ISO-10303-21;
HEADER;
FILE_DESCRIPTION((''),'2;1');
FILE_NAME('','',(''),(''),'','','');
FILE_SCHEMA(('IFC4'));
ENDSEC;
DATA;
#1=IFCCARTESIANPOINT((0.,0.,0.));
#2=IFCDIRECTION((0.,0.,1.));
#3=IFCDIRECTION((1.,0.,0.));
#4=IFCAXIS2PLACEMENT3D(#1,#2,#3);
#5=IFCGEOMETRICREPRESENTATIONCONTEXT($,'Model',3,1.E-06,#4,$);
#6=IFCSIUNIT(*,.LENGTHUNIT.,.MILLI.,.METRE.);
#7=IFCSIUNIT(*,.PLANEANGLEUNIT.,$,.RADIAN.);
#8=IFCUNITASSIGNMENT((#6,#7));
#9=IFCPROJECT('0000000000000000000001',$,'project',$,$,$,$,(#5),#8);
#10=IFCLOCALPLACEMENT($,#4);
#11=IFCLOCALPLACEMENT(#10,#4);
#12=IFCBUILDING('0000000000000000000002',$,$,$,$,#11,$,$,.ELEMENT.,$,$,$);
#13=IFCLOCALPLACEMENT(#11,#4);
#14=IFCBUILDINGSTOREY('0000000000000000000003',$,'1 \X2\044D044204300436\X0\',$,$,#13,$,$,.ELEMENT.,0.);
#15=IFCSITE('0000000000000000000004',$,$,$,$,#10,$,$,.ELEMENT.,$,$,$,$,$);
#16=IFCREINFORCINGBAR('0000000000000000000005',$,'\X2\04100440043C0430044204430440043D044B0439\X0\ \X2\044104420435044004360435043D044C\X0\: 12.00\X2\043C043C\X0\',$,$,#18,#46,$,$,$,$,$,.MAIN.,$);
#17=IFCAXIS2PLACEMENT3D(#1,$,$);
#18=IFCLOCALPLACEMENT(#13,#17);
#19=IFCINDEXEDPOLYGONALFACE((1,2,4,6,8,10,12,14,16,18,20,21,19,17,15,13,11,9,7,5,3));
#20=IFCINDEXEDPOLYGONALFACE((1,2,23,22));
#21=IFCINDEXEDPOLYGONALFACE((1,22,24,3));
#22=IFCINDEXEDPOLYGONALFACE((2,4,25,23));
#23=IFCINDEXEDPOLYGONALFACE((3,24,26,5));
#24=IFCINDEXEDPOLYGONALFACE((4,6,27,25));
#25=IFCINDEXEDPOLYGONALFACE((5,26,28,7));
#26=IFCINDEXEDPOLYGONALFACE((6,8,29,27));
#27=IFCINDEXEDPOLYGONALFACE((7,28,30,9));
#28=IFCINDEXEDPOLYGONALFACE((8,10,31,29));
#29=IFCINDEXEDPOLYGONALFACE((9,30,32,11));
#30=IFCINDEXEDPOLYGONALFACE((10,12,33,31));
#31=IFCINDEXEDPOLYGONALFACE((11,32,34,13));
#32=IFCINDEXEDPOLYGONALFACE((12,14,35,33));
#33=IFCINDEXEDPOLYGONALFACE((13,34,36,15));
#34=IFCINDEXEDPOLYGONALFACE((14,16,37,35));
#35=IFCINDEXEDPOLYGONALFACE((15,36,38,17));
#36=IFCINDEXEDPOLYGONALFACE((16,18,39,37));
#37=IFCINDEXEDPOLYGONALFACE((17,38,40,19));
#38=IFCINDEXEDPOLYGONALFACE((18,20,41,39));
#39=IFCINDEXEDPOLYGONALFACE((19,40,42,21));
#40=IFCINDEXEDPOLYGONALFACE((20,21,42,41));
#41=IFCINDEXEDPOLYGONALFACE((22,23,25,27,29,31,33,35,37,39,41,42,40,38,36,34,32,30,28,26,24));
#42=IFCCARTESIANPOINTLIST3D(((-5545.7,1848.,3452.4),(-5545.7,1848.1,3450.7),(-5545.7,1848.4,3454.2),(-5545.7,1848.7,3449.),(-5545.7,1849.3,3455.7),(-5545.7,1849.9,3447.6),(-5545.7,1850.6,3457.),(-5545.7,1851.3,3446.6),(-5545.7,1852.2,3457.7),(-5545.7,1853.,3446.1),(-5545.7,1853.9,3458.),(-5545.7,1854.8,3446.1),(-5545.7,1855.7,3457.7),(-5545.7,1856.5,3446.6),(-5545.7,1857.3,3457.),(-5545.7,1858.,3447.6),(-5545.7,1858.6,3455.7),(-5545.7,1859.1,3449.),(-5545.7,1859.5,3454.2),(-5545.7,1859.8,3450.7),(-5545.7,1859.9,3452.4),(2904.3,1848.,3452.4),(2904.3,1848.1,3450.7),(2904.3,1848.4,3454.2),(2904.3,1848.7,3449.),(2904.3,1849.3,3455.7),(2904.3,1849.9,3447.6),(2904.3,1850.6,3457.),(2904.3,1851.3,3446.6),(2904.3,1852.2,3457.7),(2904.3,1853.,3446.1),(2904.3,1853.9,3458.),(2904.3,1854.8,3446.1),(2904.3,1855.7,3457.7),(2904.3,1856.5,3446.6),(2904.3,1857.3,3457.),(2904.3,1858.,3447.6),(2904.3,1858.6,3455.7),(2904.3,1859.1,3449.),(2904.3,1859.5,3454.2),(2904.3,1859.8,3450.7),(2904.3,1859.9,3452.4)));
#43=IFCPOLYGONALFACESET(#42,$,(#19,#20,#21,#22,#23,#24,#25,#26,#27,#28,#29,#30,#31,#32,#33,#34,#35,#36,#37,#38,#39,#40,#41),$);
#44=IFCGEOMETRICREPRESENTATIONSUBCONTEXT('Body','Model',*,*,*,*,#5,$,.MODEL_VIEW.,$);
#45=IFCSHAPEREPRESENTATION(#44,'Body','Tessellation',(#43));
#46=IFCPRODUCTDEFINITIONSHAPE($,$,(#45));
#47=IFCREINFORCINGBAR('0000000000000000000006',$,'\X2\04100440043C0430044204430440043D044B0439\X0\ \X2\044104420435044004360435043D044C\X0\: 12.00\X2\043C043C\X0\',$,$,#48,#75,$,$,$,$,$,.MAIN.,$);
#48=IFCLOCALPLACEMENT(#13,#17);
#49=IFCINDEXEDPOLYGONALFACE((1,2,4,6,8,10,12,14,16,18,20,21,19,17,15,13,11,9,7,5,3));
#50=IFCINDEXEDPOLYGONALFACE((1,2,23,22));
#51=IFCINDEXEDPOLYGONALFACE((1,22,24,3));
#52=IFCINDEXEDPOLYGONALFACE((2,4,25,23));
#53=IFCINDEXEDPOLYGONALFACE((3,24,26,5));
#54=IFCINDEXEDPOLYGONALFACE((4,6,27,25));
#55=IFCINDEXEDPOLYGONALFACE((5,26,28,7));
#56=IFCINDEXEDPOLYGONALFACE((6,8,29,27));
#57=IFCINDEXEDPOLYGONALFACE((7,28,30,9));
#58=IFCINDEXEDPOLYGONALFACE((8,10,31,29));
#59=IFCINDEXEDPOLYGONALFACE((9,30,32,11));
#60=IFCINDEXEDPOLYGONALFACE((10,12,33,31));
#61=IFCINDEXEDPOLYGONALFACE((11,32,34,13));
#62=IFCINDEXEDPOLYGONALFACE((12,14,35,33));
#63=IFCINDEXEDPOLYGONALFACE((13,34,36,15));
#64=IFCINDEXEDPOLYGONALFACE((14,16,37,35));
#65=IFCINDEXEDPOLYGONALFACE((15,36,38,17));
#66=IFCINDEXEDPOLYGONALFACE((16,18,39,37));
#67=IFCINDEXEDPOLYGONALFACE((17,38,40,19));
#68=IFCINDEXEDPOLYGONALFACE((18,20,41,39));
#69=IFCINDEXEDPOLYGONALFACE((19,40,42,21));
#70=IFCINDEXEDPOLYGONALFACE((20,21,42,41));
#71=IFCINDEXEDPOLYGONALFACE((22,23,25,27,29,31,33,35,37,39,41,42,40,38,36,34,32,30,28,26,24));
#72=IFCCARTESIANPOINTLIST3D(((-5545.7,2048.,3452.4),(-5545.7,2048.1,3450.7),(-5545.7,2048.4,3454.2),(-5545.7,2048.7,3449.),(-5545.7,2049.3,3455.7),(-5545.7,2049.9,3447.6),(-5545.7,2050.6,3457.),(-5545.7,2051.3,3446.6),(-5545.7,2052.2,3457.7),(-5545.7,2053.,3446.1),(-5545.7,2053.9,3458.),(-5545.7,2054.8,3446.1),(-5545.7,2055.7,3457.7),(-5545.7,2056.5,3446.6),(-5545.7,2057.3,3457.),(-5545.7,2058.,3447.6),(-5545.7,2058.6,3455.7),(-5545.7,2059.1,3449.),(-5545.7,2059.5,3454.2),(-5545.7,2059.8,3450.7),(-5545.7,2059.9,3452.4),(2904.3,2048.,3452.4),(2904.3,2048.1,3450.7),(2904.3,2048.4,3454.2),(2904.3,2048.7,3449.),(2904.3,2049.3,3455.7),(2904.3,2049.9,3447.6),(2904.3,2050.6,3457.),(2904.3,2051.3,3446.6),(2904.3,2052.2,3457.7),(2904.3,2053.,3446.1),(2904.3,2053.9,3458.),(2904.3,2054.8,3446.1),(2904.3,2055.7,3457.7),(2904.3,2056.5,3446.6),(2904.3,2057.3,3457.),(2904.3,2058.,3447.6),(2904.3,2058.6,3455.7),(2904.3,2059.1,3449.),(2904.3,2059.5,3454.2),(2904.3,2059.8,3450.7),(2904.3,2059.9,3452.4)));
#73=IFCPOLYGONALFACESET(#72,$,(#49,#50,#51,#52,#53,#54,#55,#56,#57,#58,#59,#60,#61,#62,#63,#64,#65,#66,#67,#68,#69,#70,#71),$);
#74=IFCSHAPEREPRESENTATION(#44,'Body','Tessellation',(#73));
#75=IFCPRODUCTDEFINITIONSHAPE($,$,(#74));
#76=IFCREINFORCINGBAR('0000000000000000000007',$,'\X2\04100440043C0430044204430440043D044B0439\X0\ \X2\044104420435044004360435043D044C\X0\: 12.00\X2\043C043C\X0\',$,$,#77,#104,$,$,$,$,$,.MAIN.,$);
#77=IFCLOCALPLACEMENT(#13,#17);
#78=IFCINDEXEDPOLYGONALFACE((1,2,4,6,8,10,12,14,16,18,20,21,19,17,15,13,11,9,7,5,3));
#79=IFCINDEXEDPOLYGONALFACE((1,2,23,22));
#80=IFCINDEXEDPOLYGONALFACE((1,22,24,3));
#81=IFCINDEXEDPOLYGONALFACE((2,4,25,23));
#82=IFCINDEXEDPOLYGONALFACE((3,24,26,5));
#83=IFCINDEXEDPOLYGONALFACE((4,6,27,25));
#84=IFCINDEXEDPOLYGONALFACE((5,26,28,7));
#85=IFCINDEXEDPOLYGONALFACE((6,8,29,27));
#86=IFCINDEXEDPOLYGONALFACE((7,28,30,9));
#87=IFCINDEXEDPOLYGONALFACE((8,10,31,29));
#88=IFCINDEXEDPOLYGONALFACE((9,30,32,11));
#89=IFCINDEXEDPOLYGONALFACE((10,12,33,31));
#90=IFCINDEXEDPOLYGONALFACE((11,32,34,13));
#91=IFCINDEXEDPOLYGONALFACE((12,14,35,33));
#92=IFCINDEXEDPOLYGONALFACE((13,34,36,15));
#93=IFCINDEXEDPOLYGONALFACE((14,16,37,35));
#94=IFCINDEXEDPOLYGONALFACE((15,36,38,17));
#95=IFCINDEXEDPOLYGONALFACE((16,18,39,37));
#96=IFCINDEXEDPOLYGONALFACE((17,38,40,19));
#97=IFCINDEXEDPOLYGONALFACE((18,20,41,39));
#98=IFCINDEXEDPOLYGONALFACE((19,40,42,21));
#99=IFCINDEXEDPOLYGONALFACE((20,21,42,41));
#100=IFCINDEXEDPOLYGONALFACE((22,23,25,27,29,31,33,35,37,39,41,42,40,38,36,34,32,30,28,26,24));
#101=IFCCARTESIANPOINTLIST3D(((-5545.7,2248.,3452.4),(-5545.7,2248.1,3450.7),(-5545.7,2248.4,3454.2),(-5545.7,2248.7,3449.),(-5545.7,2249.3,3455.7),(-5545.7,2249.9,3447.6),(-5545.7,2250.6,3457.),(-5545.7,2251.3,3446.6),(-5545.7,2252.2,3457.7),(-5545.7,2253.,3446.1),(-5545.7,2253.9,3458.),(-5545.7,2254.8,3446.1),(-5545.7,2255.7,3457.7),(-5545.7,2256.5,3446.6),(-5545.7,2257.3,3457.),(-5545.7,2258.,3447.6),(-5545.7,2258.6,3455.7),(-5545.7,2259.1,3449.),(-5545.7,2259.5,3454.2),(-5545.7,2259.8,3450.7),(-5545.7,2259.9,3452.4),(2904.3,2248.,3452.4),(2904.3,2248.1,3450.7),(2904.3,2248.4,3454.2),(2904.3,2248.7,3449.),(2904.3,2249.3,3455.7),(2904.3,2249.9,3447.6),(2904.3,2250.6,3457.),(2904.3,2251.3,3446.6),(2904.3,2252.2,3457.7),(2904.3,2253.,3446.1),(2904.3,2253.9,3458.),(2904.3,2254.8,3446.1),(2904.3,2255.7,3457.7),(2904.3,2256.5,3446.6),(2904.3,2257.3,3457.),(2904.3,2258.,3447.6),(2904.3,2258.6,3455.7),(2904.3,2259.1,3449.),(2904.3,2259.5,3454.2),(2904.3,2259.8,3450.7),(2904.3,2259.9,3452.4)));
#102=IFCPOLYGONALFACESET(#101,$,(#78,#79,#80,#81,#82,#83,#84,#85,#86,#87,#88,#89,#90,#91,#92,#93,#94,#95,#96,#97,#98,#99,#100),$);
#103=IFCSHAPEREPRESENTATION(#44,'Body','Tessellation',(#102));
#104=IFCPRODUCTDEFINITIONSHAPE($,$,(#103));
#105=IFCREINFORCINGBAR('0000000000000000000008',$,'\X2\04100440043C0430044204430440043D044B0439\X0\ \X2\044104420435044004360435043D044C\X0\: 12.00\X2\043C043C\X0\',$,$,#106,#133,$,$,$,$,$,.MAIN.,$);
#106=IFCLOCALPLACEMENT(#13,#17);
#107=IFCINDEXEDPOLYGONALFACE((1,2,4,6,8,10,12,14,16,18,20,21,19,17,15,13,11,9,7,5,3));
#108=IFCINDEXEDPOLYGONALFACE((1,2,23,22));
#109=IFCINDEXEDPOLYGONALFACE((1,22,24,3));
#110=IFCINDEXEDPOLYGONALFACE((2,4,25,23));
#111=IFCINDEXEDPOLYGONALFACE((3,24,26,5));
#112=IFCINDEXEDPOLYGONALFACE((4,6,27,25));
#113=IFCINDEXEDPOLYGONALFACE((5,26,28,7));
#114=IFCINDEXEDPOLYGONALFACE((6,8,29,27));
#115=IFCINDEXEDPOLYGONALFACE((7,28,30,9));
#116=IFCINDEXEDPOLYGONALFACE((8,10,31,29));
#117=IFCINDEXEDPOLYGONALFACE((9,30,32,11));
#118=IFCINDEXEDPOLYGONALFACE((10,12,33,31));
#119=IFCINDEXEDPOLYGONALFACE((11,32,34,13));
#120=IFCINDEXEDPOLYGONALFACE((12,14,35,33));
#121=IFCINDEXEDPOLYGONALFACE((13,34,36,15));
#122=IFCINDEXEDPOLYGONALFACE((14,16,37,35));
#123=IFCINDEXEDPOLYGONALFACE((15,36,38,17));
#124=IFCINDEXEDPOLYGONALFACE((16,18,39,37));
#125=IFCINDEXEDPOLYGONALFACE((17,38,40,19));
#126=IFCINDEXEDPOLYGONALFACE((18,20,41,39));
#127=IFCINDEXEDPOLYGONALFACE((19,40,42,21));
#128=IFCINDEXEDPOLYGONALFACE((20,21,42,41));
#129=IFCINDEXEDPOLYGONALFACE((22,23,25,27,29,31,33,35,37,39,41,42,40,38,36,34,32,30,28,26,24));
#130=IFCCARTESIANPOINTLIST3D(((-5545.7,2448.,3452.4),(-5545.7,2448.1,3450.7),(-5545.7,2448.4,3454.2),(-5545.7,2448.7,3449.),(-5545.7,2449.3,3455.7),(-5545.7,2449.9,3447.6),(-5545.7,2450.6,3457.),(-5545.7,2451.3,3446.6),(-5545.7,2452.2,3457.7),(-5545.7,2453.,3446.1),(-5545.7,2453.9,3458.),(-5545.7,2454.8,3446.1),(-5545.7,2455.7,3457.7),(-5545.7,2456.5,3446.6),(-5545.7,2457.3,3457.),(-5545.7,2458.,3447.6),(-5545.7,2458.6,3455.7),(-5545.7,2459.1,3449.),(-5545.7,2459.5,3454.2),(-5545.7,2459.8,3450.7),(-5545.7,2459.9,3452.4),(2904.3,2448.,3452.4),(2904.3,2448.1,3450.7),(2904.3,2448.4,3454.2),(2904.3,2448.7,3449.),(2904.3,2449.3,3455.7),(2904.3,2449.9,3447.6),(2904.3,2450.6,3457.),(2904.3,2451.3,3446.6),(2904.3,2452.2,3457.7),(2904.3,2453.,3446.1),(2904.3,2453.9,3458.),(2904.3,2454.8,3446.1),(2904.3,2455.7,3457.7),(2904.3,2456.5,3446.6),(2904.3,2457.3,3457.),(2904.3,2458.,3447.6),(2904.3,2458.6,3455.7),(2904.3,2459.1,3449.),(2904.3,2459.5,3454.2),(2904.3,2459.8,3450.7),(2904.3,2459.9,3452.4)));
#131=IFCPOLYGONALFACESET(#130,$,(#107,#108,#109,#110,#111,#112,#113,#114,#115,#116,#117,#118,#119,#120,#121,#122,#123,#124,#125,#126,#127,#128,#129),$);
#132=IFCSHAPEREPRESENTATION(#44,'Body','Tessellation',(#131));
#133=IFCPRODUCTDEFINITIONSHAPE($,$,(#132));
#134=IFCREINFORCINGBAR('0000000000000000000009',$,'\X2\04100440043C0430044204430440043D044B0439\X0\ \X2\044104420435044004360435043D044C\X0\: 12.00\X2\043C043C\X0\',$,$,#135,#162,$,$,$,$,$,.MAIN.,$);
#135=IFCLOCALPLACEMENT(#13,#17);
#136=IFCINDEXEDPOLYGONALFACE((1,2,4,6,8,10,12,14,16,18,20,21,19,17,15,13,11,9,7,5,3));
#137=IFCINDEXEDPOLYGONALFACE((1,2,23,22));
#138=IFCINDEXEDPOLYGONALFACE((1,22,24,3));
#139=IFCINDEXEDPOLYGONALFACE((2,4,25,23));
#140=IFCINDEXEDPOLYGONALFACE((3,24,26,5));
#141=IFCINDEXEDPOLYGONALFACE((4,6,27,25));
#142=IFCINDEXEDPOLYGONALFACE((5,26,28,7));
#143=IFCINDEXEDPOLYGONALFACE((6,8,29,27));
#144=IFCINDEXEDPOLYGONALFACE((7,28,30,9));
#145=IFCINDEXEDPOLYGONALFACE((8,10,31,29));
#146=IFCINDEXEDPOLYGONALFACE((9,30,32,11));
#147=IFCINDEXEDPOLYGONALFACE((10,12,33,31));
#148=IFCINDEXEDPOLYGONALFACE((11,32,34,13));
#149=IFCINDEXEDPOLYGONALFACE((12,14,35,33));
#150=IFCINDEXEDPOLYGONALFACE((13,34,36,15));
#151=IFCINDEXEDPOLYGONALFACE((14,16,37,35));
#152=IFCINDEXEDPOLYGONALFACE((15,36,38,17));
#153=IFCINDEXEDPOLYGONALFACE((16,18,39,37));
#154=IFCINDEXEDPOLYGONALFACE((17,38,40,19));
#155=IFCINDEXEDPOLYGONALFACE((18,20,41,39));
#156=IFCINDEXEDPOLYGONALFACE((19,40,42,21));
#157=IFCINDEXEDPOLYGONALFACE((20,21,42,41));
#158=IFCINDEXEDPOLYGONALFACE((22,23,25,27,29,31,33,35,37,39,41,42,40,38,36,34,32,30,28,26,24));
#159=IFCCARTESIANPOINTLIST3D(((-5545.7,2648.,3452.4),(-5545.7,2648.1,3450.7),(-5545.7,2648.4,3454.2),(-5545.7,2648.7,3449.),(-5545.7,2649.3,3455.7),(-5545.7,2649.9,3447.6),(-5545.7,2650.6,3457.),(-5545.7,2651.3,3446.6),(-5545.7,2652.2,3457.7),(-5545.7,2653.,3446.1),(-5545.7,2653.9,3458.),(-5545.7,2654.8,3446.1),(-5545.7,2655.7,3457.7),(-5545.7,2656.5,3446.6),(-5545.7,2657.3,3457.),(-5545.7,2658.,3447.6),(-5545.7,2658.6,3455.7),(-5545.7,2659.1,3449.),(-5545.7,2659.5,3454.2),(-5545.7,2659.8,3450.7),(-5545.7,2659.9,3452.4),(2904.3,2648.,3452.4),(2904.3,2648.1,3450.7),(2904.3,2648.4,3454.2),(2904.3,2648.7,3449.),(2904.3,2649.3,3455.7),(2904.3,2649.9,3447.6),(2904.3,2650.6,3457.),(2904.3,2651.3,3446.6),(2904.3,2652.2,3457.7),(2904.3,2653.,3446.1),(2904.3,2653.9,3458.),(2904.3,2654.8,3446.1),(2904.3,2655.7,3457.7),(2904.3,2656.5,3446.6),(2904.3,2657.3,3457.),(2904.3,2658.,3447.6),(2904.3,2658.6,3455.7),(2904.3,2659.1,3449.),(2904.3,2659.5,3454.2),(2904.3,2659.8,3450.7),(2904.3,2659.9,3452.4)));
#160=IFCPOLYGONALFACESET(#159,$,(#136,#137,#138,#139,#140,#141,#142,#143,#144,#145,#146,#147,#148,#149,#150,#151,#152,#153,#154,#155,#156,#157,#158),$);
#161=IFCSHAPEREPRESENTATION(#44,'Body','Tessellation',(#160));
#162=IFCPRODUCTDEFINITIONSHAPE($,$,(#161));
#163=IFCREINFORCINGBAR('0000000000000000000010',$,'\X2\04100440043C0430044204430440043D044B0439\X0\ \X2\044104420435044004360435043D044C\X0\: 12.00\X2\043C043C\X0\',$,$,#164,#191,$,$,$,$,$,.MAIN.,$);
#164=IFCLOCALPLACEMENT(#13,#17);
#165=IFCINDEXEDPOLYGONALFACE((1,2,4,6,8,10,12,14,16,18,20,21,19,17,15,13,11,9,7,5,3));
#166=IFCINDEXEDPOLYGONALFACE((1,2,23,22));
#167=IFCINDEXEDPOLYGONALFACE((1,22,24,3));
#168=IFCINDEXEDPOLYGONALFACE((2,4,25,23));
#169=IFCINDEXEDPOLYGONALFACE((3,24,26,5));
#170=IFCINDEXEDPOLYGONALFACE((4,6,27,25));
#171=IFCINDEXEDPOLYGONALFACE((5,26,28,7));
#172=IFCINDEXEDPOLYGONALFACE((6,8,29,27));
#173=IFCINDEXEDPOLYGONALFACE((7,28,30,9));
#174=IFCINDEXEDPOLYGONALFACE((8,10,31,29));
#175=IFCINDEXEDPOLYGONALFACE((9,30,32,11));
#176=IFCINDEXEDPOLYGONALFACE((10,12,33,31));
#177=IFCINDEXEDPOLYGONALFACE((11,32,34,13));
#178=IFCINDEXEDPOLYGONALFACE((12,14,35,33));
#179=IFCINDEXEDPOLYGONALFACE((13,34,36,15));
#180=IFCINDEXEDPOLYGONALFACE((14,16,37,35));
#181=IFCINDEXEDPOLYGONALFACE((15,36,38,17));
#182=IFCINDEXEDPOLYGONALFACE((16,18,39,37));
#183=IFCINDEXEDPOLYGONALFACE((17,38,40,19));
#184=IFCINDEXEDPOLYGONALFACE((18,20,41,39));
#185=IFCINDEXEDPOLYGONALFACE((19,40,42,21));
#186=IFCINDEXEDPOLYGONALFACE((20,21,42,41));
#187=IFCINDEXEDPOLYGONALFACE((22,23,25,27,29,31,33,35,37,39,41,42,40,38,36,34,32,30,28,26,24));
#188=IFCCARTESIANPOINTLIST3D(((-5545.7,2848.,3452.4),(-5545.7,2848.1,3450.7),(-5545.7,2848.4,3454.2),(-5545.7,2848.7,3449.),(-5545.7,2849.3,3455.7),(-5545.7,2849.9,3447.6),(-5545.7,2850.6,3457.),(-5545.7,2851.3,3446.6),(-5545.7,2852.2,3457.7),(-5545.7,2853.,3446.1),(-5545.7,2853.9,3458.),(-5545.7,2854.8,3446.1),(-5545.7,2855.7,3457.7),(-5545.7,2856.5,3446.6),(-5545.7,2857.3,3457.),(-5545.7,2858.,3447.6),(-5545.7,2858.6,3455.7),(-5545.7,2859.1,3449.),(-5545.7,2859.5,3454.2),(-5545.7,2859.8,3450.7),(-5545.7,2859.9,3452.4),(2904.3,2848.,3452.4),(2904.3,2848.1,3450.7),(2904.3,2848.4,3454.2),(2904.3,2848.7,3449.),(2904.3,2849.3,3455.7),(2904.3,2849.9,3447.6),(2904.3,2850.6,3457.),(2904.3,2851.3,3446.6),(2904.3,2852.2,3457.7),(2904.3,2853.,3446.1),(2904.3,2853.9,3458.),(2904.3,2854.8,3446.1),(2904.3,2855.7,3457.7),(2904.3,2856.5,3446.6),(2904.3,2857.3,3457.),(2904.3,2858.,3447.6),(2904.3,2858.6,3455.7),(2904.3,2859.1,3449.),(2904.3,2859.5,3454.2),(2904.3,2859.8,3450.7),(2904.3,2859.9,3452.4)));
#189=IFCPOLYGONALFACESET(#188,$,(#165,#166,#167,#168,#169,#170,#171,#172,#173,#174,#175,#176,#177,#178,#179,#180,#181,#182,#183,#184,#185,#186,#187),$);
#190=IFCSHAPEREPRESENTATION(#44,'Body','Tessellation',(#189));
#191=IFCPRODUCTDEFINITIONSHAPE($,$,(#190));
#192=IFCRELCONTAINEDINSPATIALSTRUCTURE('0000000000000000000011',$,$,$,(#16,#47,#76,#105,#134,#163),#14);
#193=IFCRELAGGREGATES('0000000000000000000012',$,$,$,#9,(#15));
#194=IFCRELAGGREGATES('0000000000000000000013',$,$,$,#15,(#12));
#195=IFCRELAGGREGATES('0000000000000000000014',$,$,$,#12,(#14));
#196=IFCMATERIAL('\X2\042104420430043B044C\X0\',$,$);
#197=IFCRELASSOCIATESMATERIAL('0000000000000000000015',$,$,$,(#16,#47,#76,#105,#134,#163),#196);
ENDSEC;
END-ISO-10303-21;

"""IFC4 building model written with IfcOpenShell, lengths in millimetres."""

from ifc_helpers import new_model, entity, si_unit, origin_with_axes, place, context, subcontext, project, spatial, source, transform, mapped, material, element, save


model = new_model("IFC4")

# Units and contexts
model_context = context("Model", 3, precision=1e-06, world=origin_with_axes())
body_context = subcontext(model_context, "Body", "Model", "MODEL_VIEW")
ifc_project = project(units=[si_unit("LENGTHUNIT", "METRE", prefix="MILLI"), si_unit("PLANEANGLEUNIT", "RADIAN")], contexts=[model_context])

# Site, building, storey
site_placement = place(None, origin_with_axes())
site = spatial("IfcSite", under=ifc_project, at=site_placement, CompositionType="ELEMENT")
building_placement = place(site_placement, origin_with_axes())
building = spatial("IfcBuilding", under=site, at=building_placement, CompositionType="ELEMENT")
storey_placement = place(building_placement, origin_with_axes())
storey = spatial("IfcBuildingStorey", under=building, at=storey_placement, Name="1 этаж", CompositionType="ELEMENT", Elevation=0.0)

# Reinforcing bars
ifc_material_1 = material(Name="Сталь")
shared_shape_1 = source(origin_with_axes(), body_context, "Body", "AdvancedSweptSolid", [
    entity("IfcSweptDiskSolid", entity("IfcIndexedPolyCurve", entity("IfcCartesianPointList3D", [[0.0, 0.0, 0.0], [8450.0, 0.0, 0.0]]), [entity("IfcLineIndex", [1, 2])]), 6.0),
])
reinforcing_bar_1_placement = place(storey_placement, origin_with_axes())
element("IfcReinforcingBar", 1, at=reinforcing_bar_1_placement, inside=storey, material=ifc_material_1, Name="Арматурный стержень: 12.00мм", PredefinedType="MAIN", context=body_context, shape_type="MappedRepresentation", body=[
    mapped(shared_shape_1, transform((-5545.7, 1853.9, 3452.0), x_axis=(1.0, 0.0, 0.0), y_axis=(0.0, 1.0, 0.0), z_axis=(0.0, 0.0, 1.0), scale=1.0)),
])
reinforcing_bar_2_placement = place(storey_placement, origin_with_axes())
element("IfcReinforcingBar", 2, at=reinforcing_bar_2_placement, inside=storey, material=ifc_material_1, Name="Арматурный стержень: 12.00мм", PredefinedType="MAIN", context=body_context, shape_type="MappedRepresentation", body=[
    mapped(shared_shape_1, transform((-5545.7, 2053.9, 3452.0), x_axis=(1.0, 0.0, 0.0), y_axis=(0.0, 1.0, 0.0), z_axis=(0.0, 0.0, 1.0), scale=1.0)),
])
reinforcing_bar_3_placement = place(storey_placement, origin_with_axes())
element("IfcReinforcingBar", 3, at=reinforcing_bar_3_placement, inside=storey, material=ifc_material_1, Name="Арматурный стержень: 12.00мм", PredefinedType="MAIN", context=body_context, shape_type="MappedRepresentation", body=[
    mapped(shared_shape_1, transform((-5545.7, 2253.9, 3452.0), x_axis=(1.0, 0.0, 0.0), y_axis=(0.0, 1.0, 0.0), z_axis=(0.0, 0.0, 1.0), scale=1.0)),
])
reinforcing_bar_4_placement = place(storey_placement, origin_with_axes())
element("IfcReinforcingBar", 4, at=reinforcing_bar_4_placement, inside=storey, material=ifc_material_1, Name="Арматурный стержень: 12.00мм", PredefinedType="MAIN", context=body_context, shape_type="MappedRepresentation", body=[
    mapped(shared_shape_1, transform((-5545.7, 2453.9, 3452.0), x_axis=(1.0, 0.0, 0.0), y_axis=(0.0, 1.0, 0.0), z_axis=(0.0, 0.0, 1.0), scale=1.0)),
])
reinforcing_bar_5_placement = place(storey_placement, origin_with_axes())
element("IfcReinforcingBar", 5, at=reinforcing_bar_5_placement, inside=storey, material=ifc_material_1, Name="Арматурный стержень: 12.00мм", PredefinedType="MAIN", context=body_context, shape_type="MappedRepresentation", body=[
    mapped(shared_shape_1, transform((-5545.7, 2653.9, 3452.0), x_axis=(1.0, 0.0, 0.0), y_axis=(0.0, 1.0, 0.0), z_axis=(0.0, 0.0, 1.0), scale=1.0)),
])
reinforcing_bar_6_placement = place(storey_placement, origin_with_axes())
element("IfcReinforcingBar", 6, at=reinforcing_bar_6_placement, inside=storey, material=ifc_material_1, Name="Арматурный стержень: 12.00мм", PredefinedType="MAIN", context=body_context, shape_type="MappedRepresentation", body=[
    mapped(shared_shape_1, transform((-5545.7, 2853.9, 3452.0), x_axis=(1.0, 0.0, 0.0), y_axis=(0.0, 1.0, 0.0), z_axis=(0.0, 0.0, 1.0), scale=1.0)),
])

save(model, "model.ifc")
